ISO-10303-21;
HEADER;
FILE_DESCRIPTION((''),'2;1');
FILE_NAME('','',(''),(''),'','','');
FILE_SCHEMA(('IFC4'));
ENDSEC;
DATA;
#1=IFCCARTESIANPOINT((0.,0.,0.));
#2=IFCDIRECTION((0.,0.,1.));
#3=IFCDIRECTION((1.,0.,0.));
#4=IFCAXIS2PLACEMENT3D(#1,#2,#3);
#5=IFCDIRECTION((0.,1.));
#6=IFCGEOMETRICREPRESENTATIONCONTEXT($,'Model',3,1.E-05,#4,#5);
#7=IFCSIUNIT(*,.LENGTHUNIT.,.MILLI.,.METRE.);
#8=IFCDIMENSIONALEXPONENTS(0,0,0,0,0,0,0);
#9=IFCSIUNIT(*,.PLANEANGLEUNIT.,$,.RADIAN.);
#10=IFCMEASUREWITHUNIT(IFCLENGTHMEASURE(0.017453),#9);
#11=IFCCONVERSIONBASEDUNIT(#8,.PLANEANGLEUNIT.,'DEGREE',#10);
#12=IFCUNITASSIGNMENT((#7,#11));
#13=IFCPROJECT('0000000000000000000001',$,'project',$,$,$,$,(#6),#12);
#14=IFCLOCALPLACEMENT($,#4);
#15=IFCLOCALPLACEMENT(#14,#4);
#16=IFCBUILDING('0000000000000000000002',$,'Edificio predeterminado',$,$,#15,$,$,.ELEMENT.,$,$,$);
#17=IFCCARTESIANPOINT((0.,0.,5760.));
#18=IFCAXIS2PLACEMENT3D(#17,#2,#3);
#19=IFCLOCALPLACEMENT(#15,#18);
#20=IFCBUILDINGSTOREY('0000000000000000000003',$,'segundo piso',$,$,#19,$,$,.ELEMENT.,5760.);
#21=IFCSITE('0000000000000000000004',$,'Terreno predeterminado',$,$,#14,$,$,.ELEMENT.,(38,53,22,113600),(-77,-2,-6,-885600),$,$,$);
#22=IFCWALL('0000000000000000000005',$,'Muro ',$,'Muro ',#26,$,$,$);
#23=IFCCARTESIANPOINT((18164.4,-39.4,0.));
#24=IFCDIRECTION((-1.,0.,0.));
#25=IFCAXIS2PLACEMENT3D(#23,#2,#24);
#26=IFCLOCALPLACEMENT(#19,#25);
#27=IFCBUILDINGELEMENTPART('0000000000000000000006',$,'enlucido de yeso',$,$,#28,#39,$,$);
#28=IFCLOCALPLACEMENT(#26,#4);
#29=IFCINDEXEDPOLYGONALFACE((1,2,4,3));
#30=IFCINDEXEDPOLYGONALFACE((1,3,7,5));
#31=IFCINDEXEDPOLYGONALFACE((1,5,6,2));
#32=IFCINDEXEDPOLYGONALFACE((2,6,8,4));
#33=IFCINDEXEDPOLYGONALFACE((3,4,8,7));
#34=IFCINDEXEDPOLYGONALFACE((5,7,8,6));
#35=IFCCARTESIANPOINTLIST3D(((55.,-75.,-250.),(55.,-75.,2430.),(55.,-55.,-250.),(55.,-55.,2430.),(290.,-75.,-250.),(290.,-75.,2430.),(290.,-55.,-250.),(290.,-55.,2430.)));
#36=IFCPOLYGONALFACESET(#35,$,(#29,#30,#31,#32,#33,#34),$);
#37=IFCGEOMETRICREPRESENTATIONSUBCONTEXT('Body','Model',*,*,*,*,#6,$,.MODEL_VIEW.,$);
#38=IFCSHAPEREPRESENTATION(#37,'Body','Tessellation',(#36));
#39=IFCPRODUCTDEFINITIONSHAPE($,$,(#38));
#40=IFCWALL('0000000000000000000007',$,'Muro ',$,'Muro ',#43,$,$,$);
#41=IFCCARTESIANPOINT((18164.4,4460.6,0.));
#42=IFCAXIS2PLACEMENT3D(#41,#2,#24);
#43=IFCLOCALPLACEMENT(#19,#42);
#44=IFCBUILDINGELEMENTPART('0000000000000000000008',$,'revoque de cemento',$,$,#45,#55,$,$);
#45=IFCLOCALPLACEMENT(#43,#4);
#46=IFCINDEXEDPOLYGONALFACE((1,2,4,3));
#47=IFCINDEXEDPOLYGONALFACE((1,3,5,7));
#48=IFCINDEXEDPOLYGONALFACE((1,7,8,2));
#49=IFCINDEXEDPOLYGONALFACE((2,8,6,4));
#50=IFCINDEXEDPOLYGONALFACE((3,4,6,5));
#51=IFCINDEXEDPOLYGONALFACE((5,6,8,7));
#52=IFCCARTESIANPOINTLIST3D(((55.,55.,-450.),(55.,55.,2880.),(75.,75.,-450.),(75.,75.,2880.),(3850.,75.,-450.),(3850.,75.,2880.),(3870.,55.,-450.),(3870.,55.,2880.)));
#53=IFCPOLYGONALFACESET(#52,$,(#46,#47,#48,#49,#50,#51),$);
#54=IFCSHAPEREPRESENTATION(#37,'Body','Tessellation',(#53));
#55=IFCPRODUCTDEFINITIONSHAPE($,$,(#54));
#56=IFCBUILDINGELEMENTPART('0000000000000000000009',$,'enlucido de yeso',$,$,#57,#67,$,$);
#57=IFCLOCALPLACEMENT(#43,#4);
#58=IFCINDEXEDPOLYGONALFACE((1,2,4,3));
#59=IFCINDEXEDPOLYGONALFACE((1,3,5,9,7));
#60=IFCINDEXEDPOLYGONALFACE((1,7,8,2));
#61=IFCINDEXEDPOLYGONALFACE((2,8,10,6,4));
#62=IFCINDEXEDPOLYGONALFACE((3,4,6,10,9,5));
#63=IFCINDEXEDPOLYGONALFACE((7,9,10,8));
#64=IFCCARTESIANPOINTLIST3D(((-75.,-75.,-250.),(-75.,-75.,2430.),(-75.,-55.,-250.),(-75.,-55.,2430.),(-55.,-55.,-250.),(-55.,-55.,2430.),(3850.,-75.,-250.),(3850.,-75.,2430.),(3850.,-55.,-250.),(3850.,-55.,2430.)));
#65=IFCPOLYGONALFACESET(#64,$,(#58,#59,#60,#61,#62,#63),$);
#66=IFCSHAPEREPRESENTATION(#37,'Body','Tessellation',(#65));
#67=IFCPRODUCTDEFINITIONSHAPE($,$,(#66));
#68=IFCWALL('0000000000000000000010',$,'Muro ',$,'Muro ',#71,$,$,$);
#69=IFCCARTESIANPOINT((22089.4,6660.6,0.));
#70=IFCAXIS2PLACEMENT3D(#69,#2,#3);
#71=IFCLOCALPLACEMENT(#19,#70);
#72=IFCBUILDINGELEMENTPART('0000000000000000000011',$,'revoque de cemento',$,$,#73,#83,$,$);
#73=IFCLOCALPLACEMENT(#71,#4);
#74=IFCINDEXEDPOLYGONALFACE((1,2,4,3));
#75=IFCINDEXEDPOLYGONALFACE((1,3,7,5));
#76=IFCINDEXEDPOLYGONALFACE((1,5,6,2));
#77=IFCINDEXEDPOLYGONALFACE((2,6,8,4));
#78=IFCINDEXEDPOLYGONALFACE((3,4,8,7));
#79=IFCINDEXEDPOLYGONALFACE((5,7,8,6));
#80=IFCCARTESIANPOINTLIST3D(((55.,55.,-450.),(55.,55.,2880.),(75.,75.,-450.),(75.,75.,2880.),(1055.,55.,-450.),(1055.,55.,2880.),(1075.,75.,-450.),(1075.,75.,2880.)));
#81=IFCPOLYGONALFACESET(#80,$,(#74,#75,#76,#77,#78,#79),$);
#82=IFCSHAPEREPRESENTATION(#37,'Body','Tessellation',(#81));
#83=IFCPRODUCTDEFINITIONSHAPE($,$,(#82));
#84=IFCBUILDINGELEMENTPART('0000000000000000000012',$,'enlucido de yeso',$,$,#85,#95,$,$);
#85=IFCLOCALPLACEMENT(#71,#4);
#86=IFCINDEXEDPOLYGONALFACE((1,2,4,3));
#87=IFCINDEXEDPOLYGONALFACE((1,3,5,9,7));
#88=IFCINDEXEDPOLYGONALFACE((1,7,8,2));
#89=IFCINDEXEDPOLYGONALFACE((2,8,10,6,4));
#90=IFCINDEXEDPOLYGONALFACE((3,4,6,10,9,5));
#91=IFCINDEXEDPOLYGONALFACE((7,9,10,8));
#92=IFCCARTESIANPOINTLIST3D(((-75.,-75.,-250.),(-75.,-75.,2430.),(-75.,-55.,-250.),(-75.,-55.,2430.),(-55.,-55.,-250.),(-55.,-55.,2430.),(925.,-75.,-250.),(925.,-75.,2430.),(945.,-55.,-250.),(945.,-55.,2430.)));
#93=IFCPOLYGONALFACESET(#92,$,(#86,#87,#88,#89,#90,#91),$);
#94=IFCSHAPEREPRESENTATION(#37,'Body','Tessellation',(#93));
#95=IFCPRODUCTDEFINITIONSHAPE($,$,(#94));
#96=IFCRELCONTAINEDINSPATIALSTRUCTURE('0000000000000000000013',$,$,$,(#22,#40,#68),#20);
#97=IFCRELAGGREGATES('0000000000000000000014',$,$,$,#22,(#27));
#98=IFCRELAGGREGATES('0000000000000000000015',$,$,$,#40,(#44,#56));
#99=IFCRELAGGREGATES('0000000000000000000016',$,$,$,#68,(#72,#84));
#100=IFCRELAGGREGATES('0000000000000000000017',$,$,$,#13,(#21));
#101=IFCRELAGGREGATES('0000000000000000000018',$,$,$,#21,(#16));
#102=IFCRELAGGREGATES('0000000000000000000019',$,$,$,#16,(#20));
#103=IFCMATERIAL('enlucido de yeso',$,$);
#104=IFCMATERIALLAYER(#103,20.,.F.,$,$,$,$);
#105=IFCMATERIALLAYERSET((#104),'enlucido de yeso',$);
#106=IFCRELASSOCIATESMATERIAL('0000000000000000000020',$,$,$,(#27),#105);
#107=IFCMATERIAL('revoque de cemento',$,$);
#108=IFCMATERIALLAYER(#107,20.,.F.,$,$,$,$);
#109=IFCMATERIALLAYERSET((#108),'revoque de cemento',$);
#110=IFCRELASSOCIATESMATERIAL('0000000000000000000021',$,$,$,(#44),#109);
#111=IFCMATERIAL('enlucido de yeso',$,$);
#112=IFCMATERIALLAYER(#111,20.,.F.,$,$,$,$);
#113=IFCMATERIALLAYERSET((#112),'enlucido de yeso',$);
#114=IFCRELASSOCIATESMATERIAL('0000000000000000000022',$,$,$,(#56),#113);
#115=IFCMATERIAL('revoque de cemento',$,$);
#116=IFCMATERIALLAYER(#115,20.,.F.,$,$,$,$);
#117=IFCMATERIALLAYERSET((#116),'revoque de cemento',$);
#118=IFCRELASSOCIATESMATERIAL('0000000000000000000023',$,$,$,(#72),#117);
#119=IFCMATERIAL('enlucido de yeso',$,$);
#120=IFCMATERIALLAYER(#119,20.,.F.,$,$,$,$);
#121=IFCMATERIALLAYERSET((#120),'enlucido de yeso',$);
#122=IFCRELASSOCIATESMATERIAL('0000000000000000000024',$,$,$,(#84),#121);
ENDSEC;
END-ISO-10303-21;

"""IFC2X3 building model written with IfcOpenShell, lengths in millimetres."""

from ifc_helpers import new_model, entity, si_unit, converted_unit, direction, frame, origin_with_axes, place, context, subcontext, project, spatial, polyline, outline, extrude, material, layer, layer_set, layer_usage, element, aggregate, save


model = new_model("IFC2X3")

# Units and contexts
model_context = context("Model", 3, precision=1e-05, world=origin_with_axes(), true_north=direction((0.0, 1.0)))
body_context = subcontext(model_context, "Body", "Model", "MODEL_VIEW")
ifc_project = project(units=[si_unit("LENGTHUNIT", "METRE", prefix="MILLI"), converted_unit("PLANEANGLEUNIT", "DEGREE", entity("IfcLengthMeasure", 0.017453), si_unit("PLANEANGLEUNIT", "RADIAN"), dimensions=[0, 0, 0, 0, 0, 0, 0])], contexts=[model_context])

# Site, building, storey
site_placement = place(None, origin_with_axes())
site = spatial("IfcSite", under=ifc_project, at=site_placement, Name="Terreno predeterminado", CompositionType="ELEMENT", RefLatitude=(38, 53, 22, 113600), RefLongitude=(-77, -2, -6, -885600))
building_placement = place(site_placement, origin_with_axes())
building = spatial("IfcBuilding", under=site, at=building_placement, Name="Edificio predeterminado", CompositionType="ELEMENT")
storey_placement = place(building_placement, frame((0.0, 0.0, 5760.0), z_axis=(0.0, 0.0, 1.0), x_axis=(1.0, 0.0, 0.0)))
storey = spatial("IfcBuildingStorey", under=building, at=storey_placement, Name="segundo piso", CompositionType="ELEMENT", Elevation=5760.0)

# Wall, building element part
wall_1_placement = place(storey_placement, frame((18164.4, -39.4, 0.0), z_axis=(0.0, 0.0, 1.0), x_axis=(-1.0, 0.0, 0.0)))
wall_1 = element("IfcWall", 1, at=wall_1_placement, inside=storey, Name="Muro ", ObjectType="Muro ")
ifc_material_1 = material(Name="enlucido de yeso")
ifc_layer_1 = layer(ifc_material_1, 20.0, ventilated=False)
ifc_layer_set_1 = layer_set([ifc_layer_1], Name="enlucido de yeso")
ifc_layer_usage_1 = layer_usage(ifc_layer_set_1, "AXIS2", "NEGATIVE", 55.0)
building_element_part_1_placement = place(wall_1_placement, origin_with_axes())
building_element_part_1 = element("IfcBuildingElementPart", 2, at=building_element_part_1_placement, material=ifc_layer_usage_1, Name="enlucido de yeso", context=body_context, shape_type="SweptSolid", body=[
    extrude(outline(polyline([(290.0, -55.0), (290.0, -75.0), (55.0, -75.0), (55.0, -55.0), (290.0, -55.0)])), frame((0.0, 0.0, -250.0), z_axis=(0.0, 0.0, 1.0), x_axis=(1.0, 0.0, 0.0)), (0.0, 0.0, 1.0), 2680.0),
])
aggregate(wall_1, [building_element_part_1])

# Walls, building element parts
wall_2_placement = place(storey_placement, frame((18164.4, 4460.6, 0.0), z_axis=(0.0, 0.0, 1.0), x_axis=(-1.0, 0.0, 0.0)))
wall_2 = element("IfcWall", 3, at=wall_2_placement, inside=storey, Name="Muro ", ObjectType="Muro ")
ifc_material_2 = material(Name="revoque de cemento")
ifc_layer_2 = layer(ifc_material_2, 20.0, ventilated=False)
ifc_layer_set_2 = layer_set([ifc_layer_2], Name="revoque de cemento")
ifc_layer_usage_2 = layer_usage(ifc_layer_set_2, "AXIS2", "NEGATIVE", -75.0)
building_element_part_2_placement = place(wall_2_placement, origin_with_axes())
building_element_part_2 = element("IfcBuildingElementPart", 4, at=building_element_part_2_placement, material=ifc_layer_usage_2, Name="revoque de cemento", context=body_context, shape_type="SweptSolid", body=[
    extrude(outline(polyline([(3850.0, 75.0), (3870.0, 55.0), (55.0, 55.0), (75.0, 75.0), (3850.0, 75.0)])), frame((0.0, 0.0, -450.0), z_axis=(0.0, 0.0, 1.0), x_axis=(1.0, 0.0, 0.0)), (0.0, 0.0, 1.0), 3330.0),
])
ifc_material_3 = material(Name="enlucido de yeso")
ifc_layer_3 = layer(ifc_material_3, 20.0, ventilated=False)
ifc_layer_set_3 = layer_set([ifc_layer_3], Name="enlucido de yeso")
ifc_layer_usage_3 = layer_usage(ifc_layer_set_3, "AXIS2", "NEGATIVE", 55.0)
building_element_part_3_placement = place(wall_2_placement, origin_with_axes())
building_element_part_3 = element("IfcBuildingElementPart", 5, at=building_element_part_3_placement, material=ifc_layer_usage_3, Name="enlucido de yeso", context=body_context, shape_type="SweptSolid", body=[
    extrude(outline(polyline([(3850.0, -55.0), (3850.0, -75.0), (-75.0, -75.0), (-75.0, -55.0), (-55.0, -55.0), (3850.0, -55.0)])), frame((0.0, 0.0, -250.0), z_axis=(0.0, 0.0, 1.0), x_axis=(1.0, 0.0, 0.0)), (0.0, 0.0, 1.0), 2680.0),
])
aggregate(wall_2, [building_element_part_2, building_element_part_3])
wall_3_placement = place(storey_placement, frame((22089.4, 6660.6, 0.0), z_axis=(0.0, 0.0, 1.0), x_axis=(1.0, 0.0, 0.0)))
wall_3 = element("IfcWall", 6, at=wall_3_placement, inside=storey, Name="Muro ", ObjectType="Muro ")
ifc_material_4 = material(Name="revoque de cemento")
ifc_layer_4 = layer(ifc_material_4, 20.0, ventilated=False)
ifc_layer_set_4 = layer_set([ifc_layer_4], Name="revoque de cemento")
ifc_layer_usage_4 = layer_usage(ifc_layer_set_4, "AXIS2", "NEGATIVE", -75.0)
building_element_part_4_placement = place(wall_3_placement, origin_with_axes())
building_element_part_4 = element("IfcBuildingElementPart", 7, at=building_element_part_4_placement, material=ifc_layer_usage_4, Name="revoque de cemento", context=body_context, shape_type="SweptSolid", body=[
    extrude(outline(polyline([(1075.0, 75.0), (1055.0, 55.0), (55.0, 55.0), (75.0, 75.0), (1075.0, 75.0)])), frame((0.0, 0.0, -450.0), z_axis=(0.0, 0.0, 1.0), x_axis=(1.0, 0.0, 0.0)), (0.0, 0.0, 1.0), 3330.0),
])
ifc_material_5 = material(Name="enlucido de yeso")
ifc_layer_5 = layer(ifc_material_5, 20.0, ventilated=False)
ifc_layer_set_5 = layer_set([ifc_layer_5], Name="enlucido de yeso")
ifc_layer_usage_5 = layer_usage(ifc_layer_set_5, "AXIS2", "NEGATIVE", 55.0)
building_element_part_5_placement = place(wall_3_placement, origin_with_axes())
building_element_part_5 = element("IfcBuildingElementPart", 8, at=building_element_part_5_placement, material=ifc_layer_usage_5, Name="enlucido de yeso", context=body_context, shape_type="SweptSolid", body=[
    extrude(outline(polyline([(945.0, -55.0), (925.0, -75.0), (-75.0, -75.0), (-75.0, -55.0), (-55.0, -55.0), (945.0, -55.0)])), frame((0.0, 0.0, -250.0), z_axis=(0.0, 0.0, 1.0), x_axis=(1.0, 0.0, 0.0)), (0.0, 0.0, 1.0), 2680.0),
])
aggregate(wall_3, [building_element_part_4, building_element_part_5])

save(model, "model.ifc")
